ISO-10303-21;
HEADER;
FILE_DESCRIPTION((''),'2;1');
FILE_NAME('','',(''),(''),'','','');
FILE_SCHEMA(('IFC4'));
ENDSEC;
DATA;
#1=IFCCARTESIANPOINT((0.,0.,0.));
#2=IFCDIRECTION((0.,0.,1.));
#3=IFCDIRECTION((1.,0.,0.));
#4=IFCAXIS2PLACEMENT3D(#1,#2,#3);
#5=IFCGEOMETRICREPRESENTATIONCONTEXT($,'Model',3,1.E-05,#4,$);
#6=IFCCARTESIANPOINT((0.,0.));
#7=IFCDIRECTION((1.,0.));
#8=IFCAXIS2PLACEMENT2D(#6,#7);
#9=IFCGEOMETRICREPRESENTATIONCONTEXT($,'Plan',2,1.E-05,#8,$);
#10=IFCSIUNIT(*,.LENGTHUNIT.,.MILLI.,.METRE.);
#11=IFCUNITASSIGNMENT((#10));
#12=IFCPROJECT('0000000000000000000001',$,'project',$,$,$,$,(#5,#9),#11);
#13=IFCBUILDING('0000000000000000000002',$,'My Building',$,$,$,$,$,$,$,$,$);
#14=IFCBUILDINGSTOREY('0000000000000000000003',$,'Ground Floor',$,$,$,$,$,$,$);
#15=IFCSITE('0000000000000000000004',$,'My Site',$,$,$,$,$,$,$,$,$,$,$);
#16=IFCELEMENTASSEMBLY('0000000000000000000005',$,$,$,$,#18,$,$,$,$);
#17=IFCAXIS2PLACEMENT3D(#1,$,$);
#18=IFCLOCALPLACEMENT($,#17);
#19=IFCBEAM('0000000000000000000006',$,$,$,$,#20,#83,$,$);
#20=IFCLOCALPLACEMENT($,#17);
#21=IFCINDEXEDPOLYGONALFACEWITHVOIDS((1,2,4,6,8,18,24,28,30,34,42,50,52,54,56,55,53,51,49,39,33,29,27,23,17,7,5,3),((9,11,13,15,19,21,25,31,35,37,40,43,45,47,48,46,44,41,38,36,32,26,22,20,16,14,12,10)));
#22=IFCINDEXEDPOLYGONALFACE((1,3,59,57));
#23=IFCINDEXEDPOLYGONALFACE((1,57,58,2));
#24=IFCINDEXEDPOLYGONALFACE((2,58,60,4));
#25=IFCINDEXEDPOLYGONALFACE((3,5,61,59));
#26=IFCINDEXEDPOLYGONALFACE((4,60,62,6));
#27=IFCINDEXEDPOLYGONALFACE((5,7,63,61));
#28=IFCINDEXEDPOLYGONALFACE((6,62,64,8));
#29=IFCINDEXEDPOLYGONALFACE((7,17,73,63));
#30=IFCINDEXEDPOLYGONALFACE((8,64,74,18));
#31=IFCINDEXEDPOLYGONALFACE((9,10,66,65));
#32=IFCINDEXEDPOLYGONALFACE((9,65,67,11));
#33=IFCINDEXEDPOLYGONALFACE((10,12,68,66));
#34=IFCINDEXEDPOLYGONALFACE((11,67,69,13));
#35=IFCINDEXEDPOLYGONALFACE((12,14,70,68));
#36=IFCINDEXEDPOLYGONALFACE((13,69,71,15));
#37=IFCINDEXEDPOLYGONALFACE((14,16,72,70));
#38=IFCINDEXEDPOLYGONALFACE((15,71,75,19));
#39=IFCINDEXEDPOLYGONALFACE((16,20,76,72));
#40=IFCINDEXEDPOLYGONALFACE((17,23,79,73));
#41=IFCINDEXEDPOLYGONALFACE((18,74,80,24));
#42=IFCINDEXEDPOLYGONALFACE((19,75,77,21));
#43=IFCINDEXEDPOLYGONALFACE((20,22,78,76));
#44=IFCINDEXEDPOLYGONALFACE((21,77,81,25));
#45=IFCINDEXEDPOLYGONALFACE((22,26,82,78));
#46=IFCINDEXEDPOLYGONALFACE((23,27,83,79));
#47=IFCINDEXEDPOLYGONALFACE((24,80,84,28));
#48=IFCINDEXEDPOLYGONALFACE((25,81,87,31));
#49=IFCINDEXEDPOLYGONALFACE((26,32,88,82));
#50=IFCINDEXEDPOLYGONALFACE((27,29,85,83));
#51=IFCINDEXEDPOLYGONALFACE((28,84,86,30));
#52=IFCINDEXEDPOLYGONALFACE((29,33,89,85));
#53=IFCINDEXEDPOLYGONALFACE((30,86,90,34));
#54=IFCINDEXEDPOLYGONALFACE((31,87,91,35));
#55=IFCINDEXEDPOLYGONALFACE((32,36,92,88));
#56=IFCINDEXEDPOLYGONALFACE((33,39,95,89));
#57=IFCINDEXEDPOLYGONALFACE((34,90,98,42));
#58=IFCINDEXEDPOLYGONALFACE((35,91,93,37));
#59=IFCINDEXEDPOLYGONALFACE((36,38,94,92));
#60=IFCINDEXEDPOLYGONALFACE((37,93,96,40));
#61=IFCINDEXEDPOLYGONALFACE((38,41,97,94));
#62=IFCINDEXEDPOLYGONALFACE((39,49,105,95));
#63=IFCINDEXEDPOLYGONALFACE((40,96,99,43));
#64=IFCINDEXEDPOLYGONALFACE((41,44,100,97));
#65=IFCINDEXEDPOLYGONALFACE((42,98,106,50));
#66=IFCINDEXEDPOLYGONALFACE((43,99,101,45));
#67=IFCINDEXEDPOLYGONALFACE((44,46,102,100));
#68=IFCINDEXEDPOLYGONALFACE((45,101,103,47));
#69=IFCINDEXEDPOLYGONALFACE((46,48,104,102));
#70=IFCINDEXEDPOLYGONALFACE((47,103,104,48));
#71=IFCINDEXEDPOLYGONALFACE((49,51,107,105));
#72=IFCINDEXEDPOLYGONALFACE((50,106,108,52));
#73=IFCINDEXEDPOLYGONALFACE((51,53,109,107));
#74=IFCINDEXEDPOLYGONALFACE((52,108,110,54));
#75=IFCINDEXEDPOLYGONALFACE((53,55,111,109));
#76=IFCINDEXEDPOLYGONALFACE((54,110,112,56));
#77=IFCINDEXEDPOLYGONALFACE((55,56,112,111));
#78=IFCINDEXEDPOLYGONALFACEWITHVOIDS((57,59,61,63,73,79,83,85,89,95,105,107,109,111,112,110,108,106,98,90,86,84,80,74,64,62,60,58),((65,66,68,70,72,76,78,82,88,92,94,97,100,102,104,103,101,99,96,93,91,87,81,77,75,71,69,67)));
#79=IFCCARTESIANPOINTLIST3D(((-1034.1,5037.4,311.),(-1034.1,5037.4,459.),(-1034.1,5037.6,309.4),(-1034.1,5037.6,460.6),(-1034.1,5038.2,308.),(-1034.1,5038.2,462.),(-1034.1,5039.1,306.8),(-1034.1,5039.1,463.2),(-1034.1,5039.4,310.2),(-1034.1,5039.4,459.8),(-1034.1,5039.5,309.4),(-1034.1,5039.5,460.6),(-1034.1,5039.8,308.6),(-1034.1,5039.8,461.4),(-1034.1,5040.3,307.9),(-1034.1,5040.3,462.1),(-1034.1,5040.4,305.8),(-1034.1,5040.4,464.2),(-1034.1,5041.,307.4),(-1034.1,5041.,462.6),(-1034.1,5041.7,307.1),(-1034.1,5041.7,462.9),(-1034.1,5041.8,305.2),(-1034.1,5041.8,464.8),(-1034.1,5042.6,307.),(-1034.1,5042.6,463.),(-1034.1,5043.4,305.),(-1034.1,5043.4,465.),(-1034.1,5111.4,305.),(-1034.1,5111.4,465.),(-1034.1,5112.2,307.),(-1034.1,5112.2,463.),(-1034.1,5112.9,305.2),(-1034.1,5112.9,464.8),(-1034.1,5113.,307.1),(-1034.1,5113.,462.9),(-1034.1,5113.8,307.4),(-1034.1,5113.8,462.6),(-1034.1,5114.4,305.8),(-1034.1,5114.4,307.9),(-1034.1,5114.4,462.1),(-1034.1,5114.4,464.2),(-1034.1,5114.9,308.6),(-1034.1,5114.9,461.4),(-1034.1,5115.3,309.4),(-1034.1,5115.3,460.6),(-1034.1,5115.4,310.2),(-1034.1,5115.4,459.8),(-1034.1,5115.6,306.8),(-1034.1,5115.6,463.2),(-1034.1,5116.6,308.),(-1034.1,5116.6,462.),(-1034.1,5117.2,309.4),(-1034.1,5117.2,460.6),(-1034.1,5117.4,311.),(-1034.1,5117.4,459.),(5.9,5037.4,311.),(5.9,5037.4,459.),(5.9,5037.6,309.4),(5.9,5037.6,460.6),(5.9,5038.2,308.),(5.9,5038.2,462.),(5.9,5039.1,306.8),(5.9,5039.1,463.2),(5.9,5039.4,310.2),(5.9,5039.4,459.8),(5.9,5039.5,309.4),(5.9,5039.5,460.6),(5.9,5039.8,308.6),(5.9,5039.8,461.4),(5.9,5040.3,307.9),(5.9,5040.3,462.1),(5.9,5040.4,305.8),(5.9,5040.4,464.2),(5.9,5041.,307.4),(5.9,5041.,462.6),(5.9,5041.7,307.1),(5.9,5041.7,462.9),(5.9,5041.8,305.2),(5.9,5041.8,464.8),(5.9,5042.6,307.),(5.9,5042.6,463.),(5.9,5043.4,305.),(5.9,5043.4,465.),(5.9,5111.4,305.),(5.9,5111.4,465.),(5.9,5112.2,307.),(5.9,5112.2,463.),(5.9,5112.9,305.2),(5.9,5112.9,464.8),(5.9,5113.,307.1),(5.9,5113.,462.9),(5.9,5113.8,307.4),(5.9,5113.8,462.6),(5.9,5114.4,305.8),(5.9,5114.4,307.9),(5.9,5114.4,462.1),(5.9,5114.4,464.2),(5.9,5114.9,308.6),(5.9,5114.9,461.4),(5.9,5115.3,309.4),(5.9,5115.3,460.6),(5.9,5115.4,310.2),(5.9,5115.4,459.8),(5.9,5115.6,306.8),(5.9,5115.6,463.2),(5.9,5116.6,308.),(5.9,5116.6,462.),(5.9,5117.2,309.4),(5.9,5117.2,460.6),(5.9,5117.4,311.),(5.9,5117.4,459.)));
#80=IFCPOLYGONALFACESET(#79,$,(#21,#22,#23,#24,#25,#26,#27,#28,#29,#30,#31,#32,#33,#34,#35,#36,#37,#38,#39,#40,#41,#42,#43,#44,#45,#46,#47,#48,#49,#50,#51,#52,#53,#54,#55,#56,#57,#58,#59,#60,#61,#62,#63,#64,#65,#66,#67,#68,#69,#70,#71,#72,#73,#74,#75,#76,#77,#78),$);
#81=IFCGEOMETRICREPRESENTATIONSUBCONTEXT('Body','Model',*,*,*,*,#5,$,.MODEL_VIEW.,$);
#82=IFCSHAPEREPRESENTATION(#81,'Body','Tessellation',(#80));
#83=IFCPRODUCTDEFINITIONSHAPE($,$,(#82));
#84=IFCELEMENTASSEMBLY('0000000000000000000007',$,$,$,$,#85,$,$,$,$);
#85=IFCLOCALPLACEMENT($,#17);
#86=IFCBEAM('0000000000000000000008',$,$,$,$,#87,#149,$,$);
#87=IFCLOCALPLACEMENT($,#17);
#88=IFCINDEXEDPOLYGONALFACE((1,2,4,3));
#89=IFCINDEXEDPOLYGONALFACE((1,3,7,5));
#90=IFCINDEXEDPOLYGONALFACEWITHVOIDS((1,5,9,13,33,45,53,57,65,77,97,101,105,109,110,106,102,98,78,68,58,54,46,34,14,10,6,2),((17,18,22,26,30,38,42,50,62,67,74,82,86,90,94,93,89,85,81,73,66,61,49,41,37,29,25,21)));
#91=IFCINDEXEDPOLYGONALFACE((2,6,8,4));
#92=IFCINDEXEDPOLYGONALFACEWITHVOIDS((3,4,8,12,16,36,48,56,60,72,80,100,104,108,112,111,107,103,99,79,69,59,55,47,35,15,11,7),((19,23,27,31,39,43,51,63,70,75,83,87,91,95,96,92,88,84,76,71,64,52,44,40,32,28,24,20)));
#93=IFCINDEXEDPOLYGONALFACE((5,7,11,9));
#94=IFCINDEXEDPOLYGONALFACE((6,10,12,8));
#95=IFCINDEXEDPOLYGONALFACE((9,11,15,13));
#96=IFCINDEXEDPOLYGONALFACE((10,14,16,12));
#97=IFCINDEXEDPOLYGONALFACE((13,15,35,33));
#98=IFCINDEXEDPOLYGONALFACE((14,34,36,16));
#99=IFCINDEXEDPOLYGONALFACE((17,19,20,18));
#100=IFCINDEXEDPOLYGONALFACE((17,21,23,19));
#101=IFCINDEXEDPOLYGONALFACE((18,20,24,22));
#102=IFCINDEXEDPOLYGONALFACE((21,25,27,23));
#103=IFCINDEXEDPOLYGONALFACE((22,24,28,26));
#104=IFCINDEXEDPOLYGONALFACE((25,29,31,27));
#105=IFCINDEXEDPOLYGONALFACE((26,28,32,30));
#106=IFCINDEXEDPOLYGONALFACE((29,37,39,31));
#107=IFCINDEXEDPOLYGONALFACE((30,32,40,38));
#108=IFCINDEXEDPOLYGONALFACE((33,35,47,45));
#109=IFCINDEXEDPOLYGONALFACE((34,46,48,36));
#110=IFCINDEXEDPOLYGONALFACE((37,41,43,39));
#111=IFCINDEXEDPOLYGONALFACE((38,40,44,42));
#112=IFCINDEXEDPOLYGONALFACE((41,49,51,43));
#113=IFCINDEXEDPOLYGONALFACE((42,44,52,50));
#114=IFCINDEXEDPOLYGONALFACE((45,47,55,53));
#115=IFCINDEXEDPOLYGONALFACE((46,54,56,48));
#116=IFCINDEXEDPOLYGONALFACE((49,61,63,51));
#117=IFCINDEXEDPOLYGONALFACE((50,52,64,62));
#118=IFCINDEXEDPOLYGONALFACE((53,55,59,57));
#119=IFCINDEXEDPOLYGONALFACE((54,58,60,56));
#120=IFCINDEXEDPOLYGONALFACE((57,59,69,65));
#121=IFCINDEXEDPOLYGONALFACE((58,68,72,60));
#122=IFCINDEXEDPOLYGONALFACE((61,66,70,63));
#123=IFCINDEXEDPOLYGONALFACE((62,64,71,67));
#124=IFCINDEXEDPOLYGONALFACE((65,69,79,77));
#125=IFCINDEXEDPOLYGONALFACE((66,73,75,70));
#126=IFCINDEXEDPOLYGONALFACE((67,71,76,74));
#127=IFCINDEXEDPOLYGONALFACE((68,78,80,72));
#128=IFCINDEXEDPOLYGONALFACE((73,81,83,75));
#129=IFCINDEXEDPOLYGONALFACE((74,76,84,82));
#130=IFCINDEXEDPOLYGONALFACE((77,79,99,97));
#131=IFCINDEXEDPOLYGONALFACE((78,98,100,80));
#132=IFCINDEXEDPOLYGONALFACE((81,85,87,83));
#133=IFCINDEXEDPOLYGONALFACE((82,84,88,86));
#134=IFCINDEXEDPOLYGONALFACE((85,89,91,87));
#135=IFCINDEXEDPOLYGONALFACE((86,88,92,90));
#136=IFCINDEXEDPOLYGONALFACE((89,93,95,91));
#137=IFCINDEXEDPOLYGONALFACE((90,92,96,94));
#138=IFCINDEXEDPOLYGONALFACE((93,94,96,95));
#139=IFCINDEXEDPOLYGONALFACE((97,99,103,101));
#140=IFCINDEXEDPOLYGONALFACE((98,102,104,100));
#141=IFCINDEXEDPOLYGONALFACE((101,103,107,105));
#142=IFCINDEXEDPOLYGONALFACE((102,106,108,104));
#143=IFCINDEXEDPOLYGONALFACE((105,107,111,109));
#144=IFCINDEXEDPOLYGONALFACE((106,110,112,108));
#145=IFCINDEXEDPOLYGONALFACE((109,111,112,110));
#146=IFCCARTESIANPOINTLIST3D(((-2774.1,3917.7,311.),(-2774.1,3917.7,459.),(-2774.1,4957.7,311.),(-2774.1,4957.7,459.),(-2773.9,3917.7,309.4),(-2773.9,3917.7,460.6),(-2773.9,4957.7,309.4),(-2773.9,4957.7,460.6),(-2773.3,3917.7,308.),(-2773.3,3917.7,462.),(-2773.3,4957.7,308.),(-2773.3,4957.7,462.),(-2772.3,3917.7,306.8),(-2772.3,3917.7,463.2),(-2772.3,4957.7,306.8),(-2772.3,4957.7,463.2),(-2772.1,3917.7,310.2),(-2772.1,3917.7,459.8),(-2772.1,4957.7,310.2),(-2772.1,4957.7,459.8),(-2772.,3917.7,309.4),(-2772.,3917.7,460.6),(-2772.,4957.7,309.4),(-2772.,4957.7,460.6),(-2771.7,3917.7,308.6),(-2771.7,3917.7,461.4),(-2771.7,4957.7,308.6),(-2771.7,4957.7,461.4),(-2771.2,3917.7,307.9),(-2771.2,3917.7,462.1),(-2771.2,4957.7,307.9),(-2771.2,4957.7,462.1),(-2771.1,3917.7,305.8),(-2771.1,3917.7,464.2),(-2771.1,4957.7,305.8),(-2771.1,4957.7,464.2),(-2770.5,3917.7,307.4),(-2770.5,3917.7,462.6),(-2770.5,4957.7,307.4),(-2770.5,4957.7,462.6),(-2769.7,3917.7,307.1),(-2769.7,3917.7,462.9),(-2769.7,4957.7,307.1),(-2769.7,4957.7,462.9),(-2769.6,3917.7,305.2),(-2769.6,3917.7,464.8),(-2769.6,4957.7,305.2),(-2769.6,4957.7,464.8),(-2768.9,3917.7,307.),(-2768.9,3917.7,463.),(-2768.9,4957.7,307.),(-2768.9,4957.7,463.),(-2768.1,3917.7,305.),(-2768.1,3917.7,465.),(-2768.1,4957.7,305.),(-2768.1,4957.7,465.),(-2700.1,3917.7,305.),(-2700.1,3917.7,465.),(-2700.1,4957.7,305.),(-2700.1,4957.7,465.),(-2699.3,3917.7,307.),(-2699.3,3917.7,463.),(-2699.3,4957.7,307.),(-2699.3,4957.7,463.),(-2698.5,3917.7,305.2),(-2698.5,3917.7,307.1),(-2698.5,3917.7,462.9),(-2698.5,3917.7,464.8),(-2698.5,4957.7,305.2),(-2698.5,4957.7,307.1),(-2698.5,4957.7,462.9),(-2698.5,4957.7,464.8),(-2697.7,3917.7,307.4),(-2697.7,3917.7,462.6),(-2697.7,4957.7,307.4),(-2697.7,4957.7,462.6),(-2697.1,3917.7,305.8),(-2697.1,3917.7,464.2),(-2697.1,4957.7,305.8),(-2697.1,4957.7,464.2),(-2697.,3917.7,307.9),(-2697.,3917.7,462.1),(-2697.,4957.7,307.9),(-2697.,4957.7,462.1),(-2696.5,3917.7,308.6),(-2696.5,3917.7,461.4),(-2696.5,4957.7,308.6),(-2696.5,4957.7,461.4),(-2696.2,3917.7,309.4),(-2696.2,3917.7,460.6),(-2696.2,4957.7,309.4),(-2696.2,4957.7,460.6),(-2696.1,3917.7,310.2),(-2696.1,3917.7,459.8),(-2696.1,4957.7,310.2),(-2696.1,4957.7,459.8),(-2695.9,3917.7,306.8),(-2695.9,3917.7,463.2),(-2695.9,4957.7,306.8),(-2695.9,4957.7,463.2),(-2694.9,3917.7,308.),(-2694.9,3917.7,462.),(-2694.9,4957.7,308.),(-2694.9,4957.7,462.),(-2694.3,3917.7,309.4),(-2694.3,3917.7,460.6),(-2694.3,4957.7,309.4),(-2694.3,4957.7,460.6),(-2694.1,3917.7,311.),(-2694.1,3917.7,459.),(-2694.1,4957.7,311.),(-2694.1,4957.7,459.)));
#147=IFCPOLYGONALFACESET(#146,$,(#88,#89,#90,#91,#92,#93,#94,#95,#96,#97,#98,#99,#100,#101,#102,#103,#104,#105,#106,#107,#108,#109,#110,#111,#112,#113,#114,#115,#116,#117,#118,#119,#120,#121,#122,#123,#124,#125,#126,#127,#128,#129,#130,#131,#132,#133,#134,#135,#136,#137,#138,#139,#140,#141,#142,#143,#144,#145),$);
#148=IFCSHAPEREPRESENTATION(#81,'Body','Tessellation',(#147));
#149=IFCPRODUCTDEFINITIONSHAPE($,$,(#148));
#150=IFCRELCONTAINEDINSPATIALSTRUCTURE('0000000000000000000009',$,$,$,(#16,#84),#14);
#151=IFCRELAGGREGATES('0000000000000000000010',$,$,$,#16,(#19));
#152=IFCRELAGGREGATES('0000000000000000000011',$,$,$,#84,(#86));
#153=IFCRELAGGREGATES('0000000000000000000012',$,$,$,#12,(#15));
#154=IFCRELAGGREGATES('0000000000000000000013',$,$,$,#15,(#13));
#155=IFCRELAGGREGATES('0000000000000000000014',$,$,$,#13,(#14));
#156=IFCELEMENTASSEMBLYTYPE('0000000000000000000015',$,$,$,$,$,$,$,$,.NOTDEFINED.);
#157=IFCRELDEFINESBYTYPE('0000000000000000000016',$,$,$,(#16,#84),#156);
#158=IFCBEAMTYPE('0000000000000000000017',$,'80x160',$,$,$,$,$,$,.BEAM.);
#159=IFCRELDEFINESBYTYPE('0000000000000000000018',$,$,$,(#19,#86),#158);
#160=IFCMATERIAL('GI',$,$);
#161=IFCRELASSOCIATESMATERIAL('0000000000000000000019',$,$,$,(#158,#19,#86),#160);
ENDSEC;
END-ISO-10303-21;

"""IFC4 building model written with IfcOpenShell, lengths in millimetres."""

from ifc_helpers import new_model, si_unit, frame, origin_with_axes, origin_2d_with_axis, place, context, subcontext, project, spatial, hollow_rectangle, extrude, material, material_profile, profile_set, profile_usage, type_object, element, aggregate, save


model = new_model("IFC4")

# Units and contexts
model_context = context("Model", 3, precision=1e-05, world=origin_with_axes())
plan_context = context("Plan", 2, precision=1e-05, world=origin_2d_with_axis())
body_context = subcontext(model_context, "Body", "Model", "MODEL_VIEW")
ifc_project = project(units=[si_unit("LENGTHUNIT", "METRE", prefix="MILLI")], contexts=[model_context, plan_context])

# Site, building, storey
site = spatial("IfcSite", under=ifc_project, Name="My Site")
building = spatial("IfcBuilding", under=site, Name="My Building")
storey = spatial("IfcBuildingStorey", under=building, Name="Ground Floor")

# Shared definitions
ifc_material = material(Name="GI")

# Element assemblies, beams
element_assembly_type_1 = type_object("IfcElementAssemblyType", PredefinedType="NOTDEFINED")
ifc_material_profile_1 = material_profile(ifc_material, hollow_rectangle(XDim=80.0, YDim=160.0, WallThickness=2.0, InnerFilletRadius=3.2, OuterFilletRadius=6.0))
ifc_profile_set_1 = profile_set([ifc_material_profile_1], Name="80x160 GI Rectangular Hollow")
beam_type = type_object("IfcBeamType", Name="80x160", PredefinedType="BEAM", material=ifc_profile_set_1)
assembly_1_placement = place(None, frame((-1114.1, 5077.4, 385.0), z_axis=(1.0, 0.0, 0.0), x_axis=(0.0, 1.0, 0.0)))
assembly_1 = element("IfcElementAssembly", 1, at=assembly_1_placement, inside=storey, type_object=element_assembly_type_1)
ifc_profile_usage_1 = profile_usage(ifc_profile_set_1)
beam_1_placement = place(assembly_1_placement, frame((0.0, 0.0, 80.0), z_axis=(0.0, 0.0, 1.0), x_axis=(1.0, 0.0, 0.0)))
beam_1 = element("IfcBeam", 2, at=beam_1_placement, type_object=beam_type, material=ifc_profile_usage_1, context=body_context, shape_type="SweptSolid", body=[
    extrude(hollow_rectangle(XDim=80.0, YDim=160.0, WallThickness=2.0, InnerFilletRadius=3.2, OuterFilletRadius=6.0), origin_with_axes(), (0.0, 0.0, 1.0), 1040.0),
])
aggregate(assembly_1, [beam_1])
assembly_2_placement = place(None, frame((-2734.1, 3837.7, 385.0), z_axis=(0.0, 1.0, 0.0), x_axis=(1.0, 0.0, 0.0)))
assembly_2 = element("IfcElementAssembly", 3, at=assembly_2_placement, inside=storey, type_object=element_assembly_type_1)
ifc_profile_usage_2 = profile_usage(ifc_profile_set_1)
beam_2_placement = place(assembly_2_placement, frame((0.0, 0.0, 80.0), z_axis=(0.0, 0.0, 1.0), x_axis=(1.0, 0.0, 0.0)))
beam_2 = element("IfcBeam", 4, at=beam_2_placement, type_object=beam_type, material=ifc_profile_usage_2, context=body_context, shape_type="SweptSolid", body=[
    extrude(hollow_rectangle(XDim=80.0, YDim=160.0, WallThickness=2.0, InnerFilletRadius=3.2, OuterFilletRadius=6.0), origin_with_axes(), (0.0, 0.0, 1.0), 1040.0),
])
aggregate(assembly_2, [beam_2])

save(model, "model.ifc")
